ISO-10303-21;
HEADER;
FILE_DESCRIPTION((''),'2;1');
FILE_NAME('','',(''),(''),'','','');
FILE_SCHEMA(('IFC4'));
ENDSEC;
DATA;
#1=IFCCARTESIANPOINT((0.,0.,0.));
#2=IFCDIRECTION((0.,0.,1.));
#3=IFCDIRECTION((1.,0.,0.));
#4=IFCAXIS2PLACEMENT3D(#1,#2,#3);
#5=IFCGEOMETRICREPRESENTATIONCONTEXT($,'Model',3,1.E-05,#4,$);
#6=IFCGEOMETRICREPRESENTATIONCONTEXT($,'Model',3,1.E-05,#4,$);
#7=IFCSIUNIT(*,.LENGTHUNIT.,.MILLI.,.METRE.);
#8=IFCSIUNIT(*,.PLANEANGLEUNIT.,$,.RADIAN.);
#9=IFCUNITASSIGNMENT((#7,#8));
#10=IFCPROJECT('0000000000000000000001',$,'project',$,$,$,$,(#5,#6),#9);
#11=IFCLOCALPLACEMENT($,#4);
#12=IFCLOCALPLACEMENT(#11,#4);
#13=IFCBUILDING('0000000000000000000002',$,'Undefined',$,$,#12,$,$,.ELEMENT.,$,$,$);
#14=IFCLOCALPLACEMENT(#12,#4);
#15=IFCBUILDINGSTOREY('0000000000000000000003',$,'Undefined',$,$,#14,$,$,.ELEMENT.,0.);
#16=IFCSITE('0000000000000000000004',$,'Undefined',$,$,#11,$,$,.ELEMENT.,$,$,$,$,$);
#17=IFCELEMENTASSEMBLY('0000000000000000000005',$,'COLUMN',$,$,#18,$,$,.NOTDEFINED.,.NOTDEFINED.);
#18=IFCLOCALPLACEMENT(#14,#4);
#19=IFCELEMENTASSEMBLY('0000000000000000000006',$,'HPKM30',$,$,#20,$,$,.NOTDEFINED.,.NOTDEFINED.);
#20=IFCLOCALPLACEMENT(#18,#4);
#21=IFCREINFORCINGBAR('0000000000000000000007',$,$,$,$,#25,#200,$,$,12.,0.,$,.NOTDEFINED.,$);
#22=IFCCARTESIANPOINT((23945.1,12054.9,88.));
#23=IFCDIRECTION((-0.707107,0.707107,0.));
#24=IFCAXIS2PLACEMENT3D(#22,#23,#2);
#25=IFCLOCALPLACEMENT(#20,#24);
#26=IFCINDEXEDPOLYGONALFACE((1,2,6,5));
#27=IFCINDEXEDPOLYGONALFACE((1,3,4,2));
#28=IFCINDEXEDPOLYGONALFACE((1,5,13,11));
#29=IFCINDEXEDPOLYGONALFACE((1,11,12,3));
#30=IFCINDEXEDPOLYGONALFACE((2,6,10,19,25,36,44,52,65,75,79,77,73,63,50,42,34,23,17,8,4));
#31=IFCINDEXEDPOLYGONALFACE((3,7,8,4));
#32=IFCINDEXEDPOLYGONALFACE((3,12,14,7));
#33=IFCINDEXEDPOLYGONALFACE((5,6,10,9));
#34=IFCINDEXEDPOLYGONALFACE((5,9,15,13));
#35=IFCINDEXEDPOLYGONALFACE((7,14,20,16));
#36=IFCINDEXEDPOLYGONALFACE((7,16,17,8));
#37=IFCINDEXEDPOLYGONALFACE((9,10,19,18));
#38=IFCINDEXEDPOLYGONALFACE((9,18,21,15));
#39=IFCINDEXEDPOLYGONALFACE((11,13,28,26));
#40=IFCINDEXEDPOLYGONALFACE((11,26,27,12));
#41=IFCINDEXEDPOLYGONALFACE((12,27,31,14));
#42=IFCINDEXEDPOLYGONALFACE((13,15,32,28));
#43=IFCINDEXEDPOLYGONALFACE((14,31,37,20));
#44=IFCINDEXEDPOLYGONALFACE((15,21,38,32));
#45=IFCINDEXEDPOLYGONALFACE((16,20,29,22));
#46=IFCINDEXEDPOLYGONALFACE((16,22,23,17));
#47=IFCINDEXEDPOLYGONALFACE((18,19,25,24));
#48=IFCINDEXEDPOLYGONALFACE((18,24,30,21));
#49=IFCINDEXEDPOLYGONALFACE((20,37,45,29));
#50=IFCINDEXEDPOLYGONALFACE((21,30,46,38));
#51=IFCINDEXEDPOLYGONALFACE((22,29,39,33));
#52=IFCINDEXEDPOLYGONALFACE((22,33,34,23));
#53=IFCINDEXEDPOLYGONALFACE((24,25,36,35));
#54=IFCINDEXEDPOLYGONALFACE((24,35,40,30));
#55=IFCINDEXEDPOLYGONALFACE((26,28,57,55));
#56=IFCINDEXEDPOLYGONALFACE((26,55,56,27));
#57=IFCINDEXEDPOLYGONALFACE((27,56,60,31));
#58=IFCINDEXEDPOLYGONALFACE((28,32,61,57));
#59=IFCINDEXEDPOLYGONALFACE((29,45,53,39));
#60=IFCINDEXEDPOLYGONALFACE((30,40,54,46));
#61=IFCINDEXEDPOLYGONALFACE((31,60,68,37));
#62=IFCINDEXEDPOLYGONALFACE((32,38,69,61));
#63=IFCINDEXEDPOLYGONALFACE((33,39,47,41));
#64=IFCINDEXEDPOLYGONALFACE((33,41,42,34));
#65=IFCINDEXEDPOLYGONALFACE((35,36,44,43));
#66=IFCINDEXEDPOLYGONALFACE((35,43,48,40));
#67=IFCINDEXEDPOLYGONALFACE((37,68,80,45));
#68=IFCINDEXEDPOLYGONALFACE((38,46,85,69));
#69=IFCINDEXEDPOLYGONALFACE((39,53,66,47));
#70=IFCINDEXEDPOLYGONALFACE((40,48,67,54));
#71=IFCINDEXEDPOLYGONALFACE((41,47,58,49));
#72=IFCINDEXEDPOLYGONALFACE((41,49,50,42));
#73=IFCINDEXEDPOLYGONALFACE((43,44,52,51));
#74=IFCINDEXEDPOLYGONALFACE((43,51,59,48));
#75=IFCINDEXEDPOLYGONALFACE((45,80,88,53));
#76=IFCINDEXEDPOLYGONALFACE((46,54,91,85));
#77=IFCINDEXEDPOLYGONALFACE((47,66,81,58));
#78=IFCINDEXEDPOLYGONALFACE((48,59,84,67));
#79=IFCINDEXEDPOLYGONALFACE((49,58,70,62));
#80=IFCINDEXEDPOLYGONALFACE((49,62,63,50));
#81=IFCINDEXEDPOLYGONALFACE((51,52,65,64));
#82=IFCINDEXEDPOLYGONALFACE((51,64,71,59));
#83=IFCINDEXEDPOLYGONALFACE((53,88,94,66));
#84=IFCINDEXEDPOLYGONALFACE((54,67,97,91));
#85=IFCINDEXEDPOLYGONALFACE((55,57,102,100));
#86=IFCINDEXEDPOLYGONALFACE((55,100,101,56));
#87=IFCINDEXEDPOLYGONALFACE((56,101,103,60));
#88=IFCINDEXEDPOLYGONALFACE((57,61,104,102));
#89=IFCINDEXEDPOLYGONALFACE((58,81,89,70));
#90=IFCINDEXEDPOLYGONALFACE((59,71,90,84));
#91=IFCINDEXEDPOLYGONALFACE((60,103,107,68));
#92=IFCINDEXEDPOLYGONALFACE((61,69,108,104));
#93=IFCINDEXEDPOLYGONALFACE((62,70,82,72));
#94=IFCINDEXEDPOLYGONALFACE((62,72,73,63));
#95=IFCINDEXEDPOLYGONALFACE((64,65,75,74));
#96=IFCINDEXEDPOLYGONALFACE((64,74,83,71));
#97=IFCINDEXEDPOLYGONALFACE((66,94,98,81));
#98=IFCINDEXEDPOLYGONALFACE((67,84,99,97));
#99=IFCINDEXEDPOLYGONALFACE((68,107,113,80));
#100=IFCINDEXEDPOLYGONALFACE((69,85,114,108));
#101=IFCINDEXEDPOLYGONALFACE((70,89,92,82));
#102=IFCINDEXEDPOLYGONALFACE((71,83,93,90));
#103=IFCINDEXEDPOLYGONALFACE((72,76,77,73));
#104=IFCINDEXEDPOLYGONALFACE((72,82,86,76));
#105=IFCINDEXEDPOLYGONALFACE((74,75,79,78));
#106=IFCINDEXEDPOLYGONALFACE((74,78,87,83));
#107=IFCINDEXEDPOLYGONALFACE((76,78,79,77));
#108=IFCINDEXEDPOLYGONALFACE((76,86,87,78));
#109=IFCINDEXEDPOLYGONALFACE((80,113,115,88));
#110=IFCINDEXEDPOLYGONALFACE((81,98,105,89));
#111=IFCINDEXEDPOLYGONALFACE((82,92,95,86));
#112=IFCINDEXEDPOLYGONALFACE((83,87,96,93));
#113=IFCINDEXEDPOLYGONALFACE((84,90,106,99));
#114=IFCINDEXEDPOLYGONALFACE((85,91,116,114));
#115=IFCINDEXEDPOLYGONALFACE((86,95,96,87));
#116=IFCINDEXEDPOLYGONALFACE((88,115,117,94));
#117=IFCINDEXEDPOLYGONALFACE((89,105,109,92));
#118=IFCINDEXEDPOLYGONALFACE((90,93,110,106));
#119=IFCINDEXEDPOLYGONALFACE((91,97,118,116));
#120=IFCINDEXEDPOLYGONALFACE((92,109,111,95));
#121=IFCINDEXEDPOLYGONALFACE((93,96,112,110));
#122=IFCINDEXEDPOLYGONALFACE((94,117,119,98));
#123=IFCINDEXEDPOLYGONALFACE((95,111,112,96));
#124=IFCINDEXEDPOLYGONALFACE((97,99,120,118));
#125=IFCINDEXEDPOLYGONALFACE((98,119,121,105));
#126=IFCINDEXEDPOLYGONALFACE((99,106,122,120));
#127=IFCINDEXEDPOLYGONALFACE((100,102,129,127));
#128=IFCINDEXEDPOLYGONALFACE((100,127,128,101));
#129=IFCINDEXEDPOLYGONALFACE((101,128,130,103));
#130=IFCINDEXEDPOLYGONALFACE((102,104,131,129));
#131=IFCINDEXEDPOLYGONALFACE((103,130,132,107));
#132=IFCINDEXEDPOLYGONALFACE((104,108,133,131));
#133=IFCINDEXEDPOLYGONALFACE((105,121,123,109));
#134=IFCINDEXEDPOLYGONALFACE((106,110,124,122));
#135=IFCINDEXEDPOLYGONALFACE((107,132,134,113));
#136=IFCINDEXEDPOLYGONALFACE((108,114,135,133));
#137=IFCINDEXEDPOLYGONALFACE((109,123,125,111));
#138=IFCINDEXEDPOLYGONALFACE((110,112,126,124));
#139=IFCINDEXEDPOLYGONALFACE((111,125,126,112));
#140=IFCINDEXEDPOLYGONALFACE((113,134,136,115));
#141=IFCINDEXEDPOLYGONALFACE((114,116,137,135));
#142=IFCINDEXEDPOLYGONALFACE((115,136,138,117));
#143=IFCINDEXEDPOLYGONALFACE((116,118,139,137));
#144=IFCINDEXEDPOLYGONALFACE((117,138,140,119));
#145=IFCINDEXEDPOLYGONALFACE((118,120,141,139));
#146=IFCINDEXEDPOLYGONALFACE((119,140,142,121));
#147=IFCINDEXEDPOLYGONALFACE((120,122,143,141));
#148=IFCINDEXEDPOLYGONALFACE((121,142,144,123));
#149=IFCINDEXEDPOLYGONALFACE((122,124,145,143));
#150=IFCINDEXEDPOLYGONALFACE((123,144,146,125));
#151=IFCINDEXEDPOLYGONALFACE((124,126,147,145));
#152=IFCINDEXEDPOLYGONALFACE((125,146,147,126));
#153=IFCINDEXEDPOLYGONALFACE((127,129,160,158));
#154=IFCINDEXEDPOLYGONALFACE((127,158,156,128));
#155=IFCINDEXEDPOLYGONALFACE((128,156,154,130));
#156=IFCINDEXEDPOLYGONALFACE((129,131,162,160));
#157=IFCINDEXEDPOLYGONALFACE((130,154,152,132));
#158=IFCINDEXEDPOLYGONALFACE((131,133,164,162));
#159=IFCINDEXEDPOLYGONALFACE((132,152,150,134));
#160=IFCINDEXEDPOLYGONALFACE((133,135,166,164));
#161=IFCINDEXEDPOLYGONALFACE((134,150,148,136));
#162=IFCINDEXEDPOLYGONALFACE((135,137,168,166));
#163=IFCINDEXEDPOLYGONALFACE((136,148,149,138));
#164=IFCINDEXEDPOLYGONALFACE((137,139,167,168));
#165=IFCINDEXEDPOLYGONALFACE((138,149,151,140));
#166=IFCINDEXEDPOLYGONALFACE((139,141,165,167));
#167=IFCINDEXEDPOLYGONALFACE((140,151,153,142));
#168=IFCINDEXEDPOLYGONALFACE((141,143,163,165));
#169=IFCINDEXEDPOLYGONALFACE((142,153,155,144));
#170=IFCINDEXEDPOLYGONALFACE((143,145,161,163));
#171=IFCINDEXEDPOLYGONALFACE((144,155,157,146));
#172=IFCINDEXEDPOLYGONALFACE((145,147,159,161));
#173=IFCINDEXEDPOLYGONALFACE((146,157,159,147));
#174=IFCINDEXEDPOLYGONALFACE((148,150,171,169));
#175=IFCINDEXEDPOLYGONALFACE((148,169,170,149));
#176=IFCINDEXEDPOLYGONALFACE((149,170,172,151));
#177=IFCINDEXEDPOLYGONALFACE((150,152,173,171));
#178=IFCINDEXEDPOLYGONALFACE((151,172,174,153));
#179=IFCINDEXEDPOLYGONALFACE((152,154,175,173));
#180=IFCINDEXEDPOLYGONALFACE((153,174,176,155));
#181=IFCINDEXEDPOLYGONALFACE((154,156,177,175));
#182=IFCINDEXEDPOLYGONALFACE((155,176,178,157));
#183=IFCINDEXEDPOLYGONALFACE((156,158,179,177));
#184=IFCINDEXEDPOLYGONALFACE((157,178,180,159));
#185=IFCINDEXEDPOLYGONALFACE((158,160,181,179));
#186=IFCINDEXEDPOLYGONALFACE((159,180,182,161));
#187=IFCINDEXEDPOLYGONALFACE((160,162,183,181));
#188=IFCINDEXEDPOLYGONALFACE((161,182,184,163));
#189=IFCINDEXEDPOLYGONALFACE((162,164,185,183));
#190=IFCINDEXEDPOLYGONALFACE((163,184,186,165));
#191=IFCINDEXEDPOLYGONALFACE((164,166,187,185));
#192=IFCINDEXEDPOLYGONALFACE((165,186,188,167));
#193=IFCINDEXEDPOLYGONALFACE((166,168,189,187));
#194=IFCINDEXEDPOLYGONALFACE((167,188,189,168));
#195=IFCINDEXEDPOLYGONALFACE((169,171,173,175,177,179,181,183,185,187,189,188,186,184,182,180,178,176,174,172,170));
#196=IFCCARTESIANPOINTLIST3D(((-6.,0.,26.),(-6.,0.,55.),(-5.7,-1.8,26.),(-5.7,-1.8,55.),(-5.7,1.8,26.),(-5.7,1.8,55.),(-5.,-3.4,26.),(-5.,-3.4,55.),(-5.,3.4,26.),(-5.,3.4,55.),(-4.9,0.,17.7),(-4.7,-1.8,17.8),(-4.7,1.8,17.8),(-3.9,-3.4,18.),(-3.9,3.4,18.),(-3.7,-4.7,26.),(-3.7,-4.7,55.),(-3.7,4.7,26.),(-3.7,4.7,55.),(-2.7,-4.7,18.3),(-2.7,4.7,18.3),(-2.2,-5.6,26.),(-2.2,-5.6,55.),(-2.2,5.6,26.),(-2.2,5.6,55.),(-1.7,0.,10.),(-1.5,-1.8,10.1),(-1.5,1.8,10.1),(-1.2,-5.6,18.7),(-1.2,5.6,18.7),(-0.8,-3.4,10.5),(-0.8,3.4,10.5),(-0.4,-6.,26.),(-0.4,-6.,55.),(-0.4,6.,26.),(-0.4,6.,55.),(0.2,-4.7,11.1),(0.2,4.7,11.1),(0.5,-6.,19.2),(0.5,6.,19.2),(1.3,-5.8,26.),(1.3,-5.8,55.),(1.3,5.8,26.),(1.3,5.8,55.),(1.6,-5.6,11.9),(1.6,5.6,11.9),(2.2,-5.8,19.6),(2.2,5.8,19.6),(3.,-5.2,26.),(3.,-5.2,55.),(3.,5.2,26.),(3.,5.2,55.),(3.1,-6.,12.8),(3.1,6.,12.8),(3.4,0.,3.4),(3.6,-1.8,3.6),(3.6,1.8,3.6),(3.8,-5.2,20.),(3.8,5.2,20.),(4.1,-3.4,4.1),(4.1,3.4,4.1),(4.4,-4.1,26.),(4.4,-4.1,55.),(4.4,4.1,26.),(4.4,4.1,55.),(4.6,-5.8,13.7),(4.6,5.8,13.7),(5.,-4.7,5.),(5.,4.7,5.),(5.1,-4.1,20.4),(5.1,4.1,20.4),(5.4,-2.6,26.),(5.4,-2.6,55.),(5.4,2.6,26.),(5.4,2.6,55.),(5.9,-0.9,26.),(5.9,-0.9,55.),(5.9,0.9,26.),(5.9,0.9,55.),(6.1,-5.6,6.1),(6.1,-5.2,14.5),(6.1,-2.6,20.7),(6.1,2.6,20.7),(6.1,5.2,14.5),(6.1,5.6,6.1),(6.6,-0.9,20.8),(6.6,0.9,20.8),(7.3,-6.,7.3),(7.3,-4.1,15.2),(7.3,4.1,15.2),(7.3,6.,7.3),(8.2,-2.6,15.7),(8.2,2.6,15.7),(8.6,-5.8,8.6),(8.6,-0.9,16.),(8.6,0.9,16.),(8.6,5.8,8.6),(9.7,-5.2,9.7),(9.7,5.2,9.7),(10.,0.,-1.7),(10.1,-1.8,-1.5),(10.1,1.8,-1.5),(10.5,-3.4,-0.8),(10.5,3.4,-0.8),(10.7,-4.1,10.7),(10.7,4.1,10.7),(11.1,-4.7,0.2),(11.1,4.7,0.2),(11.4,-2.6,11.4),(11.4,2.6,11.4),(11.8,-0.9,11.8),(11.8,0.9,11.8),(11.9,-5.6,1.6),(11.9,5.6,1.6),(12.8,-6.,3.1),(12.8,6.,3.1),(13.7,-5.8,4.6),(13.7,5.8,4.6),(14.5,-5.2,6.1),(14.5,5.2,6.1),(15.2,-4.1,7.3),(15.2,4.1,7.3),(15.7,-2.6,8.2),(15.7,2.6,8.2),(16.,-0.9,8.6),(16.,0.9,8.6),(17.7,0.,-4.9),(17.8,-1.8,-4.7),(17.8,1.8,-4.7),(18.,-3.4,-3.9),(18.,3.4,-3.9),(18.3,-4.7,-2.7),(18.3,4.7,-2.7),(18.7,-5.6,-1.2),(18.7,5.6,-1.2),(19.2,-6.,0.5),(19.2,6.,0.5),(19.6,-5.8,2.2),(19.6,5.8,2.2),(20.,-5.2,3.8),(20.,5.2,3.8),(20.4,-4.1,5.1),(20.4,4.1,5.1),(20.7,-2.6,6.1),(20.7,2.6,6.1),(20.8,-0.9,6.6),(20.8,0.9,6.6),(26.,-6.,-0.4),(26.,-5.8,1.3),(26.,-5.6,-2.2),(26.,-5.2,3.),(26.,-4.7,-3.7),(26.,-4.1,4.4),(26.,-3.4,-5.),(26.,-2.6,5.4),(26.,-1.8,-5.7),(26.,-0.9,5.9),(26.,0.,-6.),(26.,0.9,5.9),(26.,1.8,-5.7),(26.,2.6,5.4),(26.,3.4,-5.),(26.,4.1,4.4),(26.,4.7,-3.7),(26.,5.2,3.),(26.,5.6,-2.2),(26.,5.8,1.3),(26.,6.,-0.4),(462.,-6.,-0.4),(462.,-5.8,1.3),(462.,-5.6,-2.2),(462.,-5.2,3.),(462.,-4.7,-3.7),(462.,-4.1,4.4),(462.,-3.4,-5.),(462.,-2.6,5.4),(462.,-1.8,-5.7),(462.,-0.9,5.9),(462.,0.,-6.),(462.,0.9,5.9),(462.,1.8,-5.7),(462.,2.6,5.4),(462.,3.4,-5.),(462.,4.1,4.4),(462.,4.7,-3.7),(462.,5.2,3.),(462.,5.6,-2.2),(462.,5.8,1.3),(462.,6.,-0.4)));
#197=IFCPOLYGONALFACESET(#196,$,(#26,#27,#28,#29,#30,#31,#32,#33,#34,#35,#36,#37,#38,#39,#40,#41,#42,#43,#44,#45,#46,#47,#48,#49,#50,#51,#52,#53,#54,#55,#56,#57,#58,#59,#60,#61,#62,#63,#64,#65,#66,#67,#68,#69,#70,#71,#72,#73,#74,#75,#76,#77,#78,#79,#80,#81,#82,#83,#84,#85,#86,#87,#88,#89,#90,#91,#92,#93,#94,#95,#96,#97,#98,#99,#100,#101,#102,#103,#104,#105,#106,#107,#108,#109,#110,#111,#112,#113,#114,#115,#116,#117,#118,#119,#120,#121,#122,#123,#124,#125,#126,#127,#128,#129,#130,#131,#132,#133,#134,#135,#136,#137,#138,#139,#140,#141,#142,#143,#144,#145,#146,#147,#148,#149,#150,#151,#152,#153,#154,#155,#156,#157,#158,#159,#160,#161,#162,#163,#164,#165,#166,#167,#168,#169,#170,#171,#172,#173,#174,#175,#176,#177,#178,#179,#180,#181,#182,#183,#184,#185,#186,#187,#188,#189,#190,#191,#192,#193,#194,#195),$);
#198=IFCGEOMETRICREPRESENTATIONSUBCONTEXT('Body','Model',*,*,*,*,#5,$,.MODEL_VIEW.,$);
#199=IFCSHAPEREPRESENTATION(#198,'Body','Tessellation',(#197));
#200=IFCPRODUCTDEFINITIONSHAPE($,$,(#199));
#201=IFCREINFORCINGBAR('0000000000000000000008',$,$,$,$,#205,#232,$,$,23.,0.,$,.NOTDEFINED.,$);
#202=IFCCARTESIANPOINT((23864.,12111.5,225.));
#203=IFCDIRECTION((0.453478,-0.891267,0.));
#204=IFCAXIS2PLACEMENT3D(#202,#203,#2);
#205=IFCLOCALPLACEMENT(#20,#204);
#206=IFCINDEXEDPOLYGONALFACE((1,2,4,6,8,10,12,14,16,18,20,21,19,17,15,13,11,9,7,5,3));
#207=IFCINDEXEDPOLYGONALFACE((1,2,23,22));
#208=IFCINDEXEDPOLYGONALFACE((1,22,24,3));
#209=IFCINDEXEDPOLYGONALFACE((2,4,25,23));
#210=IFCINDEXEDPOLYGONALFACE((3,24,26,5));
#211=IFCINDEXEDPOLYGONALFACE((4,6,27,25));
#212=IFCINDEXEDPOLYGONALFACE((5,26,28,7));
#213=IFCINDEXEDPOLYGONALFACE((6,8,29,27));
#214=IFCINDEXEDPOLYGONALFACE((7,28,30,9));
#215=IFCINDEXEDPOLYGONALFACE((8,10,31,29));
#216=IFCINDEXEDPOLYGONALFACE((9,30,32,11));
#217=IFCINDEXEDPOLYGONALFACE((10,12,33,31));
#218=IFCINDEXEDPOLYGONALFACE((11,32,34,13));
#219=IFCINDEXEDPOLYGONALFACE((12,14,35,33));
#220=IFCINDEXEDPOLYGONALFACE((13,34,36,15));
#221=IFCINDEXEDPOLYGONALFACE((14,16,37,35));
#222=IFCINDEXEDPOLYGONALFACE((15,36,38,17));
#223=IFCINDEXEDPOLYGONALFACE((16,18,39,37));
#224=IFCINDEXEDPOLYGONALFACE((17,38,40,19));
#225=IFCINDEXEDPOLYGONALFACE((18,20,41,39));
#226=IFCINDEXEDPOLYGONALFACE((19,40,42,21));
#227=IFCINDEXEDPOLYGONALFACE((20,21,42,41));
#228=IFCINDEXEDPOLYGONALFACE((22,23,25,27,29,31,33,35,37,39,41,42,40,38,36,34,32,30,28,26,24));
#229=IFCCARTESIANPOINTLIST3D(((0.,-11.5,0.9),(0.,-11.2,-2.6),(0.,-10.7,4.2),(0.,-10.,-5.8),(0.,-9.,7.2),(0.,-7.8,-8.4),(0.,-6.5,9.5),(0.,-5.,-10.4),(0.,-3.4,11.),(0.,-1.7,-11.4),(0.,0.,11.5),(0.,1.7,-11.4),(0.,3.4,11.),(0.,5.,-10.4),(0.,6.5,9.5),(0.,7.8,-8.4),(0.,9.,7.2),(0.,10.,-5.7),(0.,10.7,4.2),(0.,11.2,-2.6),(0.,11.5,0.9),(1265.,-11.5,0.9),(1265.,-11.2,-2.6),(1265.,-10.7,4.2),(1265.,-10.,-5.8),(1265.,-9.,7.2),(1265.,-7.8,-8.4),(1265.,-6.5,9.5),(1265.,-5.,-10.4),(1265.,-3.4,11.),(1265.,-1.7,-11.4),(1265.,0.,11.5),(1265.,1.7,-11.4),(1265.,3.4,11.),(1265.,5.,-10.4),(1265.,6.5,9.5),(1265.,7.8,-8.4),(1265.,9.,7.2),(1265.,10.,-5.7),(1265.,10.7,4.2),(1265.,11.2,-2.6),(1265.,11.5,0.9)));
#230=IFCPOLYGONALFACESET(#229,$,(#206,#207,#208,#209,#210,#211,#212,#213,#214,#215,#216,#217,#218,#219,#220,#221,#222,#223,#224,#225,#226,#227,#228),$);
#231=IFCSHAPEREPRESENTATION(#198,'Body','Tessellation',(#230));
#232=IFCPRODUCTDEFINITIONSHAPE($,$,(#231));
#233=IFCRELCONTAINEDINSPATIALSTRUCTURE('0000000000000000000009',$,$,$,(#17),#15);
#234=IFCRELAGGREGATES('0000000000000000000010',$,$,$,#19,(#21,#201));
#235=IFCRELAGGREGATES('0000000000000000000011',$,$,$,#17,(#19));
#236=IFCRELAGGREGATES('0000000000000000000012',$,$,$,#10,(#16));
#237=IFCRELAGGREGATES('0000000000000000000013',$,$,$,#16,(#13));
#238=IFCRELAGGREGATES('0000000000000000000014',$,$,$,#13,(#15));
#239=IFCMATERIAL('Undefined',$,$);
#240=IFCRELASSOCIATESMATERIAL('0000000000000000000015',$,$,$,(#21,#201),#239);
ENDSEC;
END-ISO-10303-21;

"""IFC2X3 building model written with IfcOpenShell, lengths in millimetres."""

from ifc_helpers import new_model, entity, si_unit, frame, origin_with_axes, place, context, subcontext, project, spatial, source, transform, mapped, material, element, aggregate, save


model = new_model("IFC2X3")

# Units and contexts
model_context_1 = context("Model", 3, precision=1e-05, world=origin_with_axes())
model_context_2 = context("Model", 3, precision=1e-05, world=origin_with_axes())
body_context = subcontext(model_context_1, "Body", "Model", "MODEL_VIEW")
ifc_project = project(units=[si_unit("LENGTHUNIT", "METRE", prefix="MILLI"), si_unit("PLANEANGLEUNIT", "RADIAN")], contexts=[model_context_1, model_context_2])

# Site, building, storey
site_placement = place(None, origin_with_axes())
site = spatial("IfcSite", under=ifc_project, at=site_placement, Name="Undefined", CompositionType="ELEMENT")
building_placement = place(site_placement, origin_with_axes())
building = spatial("IfcBuilding", under=site, at=building_placement, Name="Undefined", CompositionType="ELEMENT")
storey_placement = place(building_placement, origin_with_axes())
storey = spatial("IfcBuildingStorey", under=building, at=storey_placement, Name="Undefined", CompositionType="ELEMENT", Elevation=0.0)

# Element assembly
assembly_1_placement = place(storey_placement, origin_with_axes())
assembly_1 = element("IfcElementAssembly", 1, at=assembly_1_placement, inside=storey, Name="COLUMN", AssemblyPlace="NOTDEFINED", PredefinedType="NOTDEFINED")

# Element assembly
assembly_2_placement = place(assembly_1_placement, origin_with_axes())
assembly_2 = element("IfcElementAssembly", 2, at=assembly_2_placement, Name="HPKM30", AssemblyPlace="NOTDEFINED", PredefinedType="NOTDEFINED")

# Shared definitions
ifc_material_1 = material(Name="Undefined")

# Reinforcing bars
shared_shape_1 = source(origin_with_axes(), body_context, "Body", "AdvancedSweptSolid", [
    entity("IfcSweptDiskSolid", entity("IfcCompositeCurve", [entity("IfcCompositeCurveSegment", "CONTINUOUS", True, entity("IfcTrimmedCurve", entity("IfcLine", entity("IfcCartesianPoint", [0.0, 0.0, 0.0]), entity("IfcVector", entity("IfcDirection", [0.0, 0.0, -1.0]), 1.0)), [entity("IfcParameterValue", 0.0)], [entity("IfcParameterValue", 29.0)], True, "PARAMETER")), entity("IfcCompositeCurveSegment", "CONTINUOUS", True, entity("IfcTrimmedCurve", entity("IfcCircle", entity("IfcAxis2Placement3D", entity("IfcCartesianPoint", [26.0, 0.0, -29.0]), entity("IfcDirection", [0.0, -1.0, 0.0]), entity("IfcDirection", [-1.0, 0.0, 0.0])), 26.0), [entity("IfcParameterValue", 0.0)], [entity("IfcParameterValue", 1.570796)], True, "PARAMETER")), entity("IfcCompositeCurveSegment", "DISCONTINUOUS", True, entity("IfcTrimmedCurve", entity("IfcLine", entity("IfcCartesianPoint", [26.0, 0.0, -55.0]), entity("IfcVector", entity("IfcDirection", [1.0, 0.0, 0.0]), 1.0)), [entity("IfcParameterValue", 0.0)], [entity("IfcParameterValue", 436.0)], True, "PARAMETER"))], False), 6.0, None, 0.0, 466.6),
])
reinforcing_bar_1_placement = place(assembly_2_placement, frame((23945.1, 12054.9, 88.0), z_axis=(-0.707107, 0.707107, 0.0), x_axis=(0.0, 0.0, 1.0)))
reinforcing_bar_1 = element("IfcReinforcingBar", 3, at=reinforcing_bar_1_placement, material=ifc_material_1, BarRole="NOTDEFINED", CrossSectionArea=0.0, NominalDiameter=12.0, context=body_context, shape_type="MappedRepresentation", body=[
    mapped(shared_shape_1, transform((0.0, 0.0, 55.0))),
])
shared_shape_2 = source(origin_with_axes(), body_context, "Body", "AdvancedSweptSolid", [
    entity("IfcSweptDiskSolid", entity("IfcTrimmedCurve", entity("IfcLine", entity("IfcCartesianPoint", [0.0, 0.0, 0.0]), entity("IfcVector", entity("IfcDirection", [1.0, 0.0, 0.0]), 1.0)), [entity("IfcParameterValue", 0.0)], [entity("IfcParameterValue", 1265.0)], True, "PARAMETER"), 11.5, None, 0.0, 1265.0),
])
reinforcing_bar_2_placement = place(assembly_2_placement, frame((23864.0, 12111.5, 225.0), z_axis=(0.453478, -0.891267, 0.0), x_axis=(0.0, 0.0, 1.0)))
reinforcing_bar_2 = element("IfcReinforcingBar", 4, at=reinforcing_bar_2_placement, material=ifc_material_1, BarRole="NOTDEFINED", CrossSectionArea=0.0, NominalDiameter=23.0, context=body_context, shape_type="MappedRepresentation", body=[
    mapped(shared_shape_2, transform((0.0, 0.0, 0.0))),
])
aggregate(assembly_2, [reinforcing_bar_1, reinforcing_bar_2])
aggregate(assembly_1, [assembly_2])

save(model, "model.ifc")
